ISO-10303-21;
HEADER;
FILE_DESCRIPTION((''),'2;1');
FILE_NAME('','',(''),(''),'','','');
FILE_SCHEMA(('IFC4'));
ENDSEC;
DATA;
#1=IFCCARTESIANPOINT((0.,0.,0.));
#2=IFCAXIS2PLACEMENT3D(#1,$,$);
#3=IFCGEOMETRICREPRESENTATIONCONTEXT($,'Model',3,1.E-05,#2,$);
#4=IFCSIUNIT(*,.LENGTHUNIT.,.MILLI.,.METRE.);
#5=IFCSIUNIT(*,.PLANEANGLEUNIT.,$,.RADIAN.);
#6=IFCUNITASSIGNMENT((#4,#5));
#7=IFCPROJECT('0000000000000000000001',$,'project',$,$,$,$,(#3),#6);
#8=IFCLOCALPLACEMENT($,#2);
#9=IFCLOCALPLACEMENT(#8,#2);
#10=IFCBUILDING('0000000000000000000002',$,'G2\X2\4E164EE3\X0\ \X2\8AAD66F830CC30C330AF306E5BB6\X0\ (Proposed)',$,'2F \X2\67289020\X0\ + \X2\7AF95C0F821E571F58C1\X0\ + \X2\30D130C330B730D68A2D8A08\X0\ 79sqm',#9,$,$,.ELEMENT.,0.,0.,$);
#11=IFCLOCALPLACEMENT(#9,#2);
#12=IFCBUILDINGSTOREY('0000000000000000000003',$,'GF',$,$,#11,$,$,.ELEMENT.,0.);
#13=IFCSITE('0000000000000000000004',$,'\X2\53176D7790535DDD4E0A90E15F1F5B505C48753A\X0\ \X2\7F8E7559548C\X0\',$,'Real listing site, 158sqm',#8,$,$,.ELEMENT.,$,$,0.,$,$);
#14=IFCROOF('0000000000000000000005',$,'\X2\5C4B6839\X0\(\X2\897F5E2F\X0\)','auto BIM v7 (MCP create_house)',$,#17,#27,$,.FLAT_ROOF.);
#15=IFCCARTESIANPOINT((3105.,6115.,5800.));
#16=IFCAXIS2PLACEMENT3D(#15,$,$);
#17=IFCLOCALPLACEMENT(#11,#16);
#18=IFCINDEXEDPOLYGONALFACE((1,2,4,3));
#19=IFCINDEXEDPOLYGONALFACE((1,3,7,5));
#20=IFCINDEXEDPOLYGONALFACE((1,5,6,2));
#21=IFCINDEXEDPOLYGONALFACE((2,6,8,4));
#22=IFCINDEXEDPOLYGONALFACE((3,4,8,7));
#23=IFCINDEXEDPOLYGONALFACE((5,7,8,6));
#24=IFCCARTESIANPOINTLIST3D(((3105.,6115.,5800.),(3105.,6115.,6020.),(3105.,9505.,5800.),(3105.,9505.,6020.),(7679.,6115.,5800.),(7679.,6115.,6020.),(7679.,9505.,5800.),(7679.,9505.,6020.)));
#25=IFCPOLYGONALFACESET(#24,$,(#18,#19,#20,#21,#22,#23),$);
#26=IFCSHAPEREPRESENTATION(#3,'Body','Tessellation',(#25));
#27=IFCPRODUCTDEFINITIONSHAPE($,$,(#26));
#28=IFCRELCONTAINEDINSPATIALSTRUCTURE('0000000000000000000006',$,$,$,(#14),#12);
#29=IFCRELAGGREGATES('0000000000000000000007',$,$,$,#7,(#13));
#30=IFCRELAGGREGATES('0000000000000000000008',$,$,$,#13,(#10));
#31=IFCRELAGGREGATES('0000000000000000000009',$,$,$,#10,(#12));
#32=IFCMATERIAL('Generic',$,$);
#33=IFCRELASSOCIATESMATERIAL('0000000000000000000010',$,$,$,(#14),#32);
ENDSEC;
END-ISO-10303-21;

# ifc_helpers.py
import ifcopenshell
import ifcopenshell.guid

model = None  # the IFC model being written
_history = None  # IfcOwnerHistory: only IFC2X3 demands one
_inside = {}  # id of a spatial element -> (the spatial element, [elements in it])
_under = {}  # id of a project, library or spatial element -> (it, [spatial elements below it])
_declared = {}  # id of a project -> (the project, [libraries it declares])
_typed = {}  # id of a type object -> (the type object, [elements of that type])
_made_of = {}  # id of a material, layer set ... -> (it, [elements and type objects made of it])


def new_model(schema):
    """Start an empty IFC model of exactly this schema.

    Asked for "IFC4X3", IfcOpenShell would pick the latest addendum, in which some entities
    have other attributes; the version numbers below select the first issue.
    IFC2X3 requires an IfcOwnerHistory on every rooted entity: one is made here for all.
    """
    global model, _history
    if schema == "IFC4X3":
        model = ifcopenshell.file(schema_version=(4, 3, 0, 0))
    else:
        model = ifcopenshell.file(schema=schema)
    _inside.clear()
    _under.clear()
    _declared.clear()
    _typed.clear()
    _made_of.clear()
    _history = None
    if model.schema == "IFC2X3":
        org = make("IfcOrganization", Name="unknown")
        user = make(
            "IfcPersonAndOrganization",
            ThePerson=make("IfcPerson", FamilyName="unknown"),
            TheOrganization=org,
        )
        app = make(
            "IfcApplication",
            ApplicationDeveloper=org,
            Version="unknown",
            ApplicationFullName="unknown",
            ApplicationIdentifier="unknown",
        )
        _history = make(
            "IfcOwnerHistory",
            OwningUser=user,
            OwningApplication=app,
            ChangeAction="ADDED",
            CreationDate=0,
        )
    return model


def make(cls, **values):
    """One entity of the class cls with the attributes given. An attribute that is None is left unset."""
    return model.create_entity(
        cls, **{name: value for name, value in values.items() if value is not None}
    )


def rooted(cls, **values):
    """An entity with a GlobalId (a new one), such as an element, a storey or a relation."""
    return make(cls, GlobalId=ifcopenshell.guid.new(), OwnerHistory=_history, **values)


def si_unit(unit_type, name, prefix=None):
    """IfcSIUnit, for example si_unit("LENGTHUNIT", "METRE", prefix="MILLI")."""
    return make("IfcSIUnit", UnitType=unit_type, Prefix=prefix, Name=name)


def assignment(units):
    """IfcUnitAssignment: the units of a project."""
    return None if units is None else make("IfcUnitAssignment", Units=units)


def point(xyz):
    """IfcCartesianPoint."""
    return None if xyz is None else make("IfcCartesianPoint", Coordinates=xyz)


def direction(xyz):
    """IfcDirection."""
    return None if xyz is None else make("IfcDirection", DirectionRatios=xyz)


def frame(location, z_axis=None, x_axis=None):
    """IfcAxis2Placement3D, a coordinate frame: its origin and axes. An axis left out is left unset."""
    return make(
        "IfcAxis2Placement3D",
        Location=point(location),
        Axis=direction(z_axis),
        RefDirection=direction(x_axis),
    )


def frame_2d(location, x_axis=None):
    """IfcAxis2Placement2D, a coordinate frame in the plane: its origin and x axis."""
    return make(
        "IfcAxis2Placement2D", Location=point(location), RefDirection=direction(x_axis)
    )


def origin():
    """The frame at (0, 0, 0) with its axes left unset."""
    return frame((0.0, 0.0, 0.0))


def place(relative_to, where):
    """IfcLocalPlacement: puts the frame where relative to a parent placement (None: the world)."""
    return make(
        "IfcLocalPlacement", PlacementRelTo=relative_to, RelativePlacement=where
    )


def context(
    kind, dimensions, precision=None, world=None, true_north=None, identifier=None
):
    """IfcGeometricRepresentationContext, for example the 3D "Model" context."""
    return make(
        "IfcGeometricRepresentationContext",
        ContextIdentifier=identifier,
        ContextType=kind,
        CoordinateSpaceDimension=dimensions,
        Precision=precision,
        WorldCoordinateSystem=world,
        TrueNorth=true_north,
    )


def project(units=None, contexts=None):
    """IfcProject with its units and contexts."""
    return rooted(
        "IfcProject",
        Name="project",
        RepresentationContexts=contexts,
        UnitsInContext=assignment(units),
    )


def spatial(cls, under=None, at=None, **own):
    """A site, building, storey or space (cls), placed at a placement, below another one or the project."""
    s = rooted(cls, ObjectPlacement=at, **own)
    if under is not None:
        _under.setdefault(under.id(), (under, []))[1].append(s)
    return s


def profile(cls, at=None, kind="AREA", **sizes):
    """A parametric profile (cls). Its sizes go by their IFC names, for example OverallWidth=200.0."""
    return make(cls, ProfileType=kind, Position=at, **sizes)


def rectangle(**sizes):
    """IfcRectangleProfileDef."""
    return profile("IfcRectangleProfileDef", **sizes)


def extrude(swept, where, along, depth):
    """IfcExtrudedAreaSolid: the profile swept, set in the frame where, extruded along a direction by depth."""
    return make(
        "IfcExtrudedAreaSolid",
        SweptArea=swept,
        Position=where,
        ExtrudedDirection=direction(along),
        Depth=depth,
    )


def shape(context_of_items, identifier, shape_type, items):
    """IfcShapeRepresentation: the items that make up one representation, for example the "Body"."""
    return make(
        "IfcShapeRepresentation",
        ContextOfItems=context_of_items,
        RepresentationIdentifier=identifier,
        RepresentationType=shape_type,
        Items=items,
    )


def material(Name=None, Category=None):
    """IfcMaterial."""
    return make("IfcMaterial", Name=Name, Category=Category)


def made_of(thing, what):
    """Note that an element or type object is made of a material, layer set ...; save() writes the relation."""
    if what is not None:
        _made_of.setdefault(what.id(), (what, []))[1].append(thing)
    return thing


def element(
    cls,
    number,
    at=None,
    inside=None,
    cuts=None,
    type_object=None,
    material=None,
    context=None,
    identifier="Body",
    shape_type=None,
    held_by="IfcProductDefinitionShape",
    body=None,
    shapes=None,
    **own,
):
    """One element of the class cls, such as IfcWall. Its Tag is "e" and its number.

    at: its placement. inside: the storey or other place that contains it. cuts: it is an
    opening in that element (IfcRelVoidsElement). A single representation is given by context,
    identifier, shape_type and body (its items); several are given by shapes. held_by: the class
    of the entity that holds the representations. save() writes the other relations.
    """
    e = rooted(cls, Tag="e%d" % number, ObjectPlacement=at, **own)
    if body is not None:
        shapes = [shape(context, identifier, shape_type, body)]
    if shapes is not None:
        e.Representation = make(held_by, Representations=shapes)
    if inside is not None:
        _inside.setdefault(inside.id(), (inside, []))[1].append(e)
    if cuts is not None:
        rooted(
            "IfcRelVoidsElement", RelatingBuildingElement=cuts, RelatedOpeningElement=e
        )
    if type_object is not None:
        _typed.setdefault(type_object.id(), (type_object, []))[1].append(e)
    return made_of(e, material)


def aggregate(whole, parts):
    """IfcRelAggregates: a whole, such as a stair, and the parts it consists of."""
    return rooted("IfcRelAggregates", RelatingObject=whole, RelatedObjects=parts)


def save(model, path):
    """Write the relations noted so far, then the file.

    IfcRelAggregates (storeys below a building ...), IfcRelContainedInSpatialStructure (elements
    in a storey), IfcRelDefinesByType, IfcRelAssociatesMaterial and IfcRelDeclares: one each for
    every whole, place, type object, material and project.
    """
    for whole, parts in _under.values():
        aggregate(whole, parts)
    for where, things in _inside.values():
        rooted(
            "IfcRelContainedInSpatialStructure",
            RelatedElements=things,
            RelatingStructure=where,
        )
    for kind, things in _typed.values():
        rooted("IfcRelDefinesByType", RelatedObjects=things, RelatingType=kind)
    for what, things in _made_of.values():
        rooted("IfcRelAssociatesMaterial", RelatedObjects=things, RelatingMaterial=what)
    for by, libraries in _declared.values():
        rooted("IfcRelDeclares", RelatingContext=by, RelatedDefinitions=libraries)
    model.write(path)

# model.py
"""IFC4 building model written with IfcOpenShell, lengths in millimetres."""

from ifc_helpers import new_model, si_unit, frame, frame_2d, origin, place, context, project, spatial, rectangle, extrude, material, element, save


model = new_model("IFC4")

# Units and contexts
model_context = context("Model", 3, precision=1e-05, world=origin())
ifc_project = project(units=[si_unit("LENGTHUNIT", "METRE", prefix="MILLI"), si_unit("PLANEANGLEUNIT", "RADIAN")], contexts=[model_context])

# Site, building, storey
site_placement = place(None, origin())
site = spatial("IfcSite", under=ifc_project, at=site_placement, Name="北海道川上郡弟子屈町 美留和", ObjectType="Real listing site, 158sqm", CompositionType="ELEMENT", RefElevation=0.0)
building_placement = place(site_placement, origin())
building = spatial("IfcBuilding", under=site, at=building_placement, Name="G2世代 読書ヌックの家 (Proposed)", ObjectType="2F 木造 + 竹小舞土壁 + パッシブ設計 79sqm", CompositionType="ELEMENT", ElevationOfRefHeight=0.0, ElevationOfTerrain=0.0)
storey_placement = place(building_placement, origin())
storey = spatial("IfcBuildingStorey", under=building, at=storey_placement, Name="GF", CompositionType="ELEMENT", Elevation=0.0)

# Shared definitions
ifc_material = material(Name="Generic")

# Roof
roof_1_placement = place(storey_placement, frame((3105.0, 6115.0, 5800.0)))
element("IfcRoof", 1, at=roof_1_placement, inside=storey, material=ifc_material, Name="屋根(西帯)", Description="auto BIM v7 (MCP create_house)", PredefinedType="FLAT_ROOF", context=model_context, shape_type="SweptSolid", body=[
    extrude(rectangle(XDim=4574.0, YDim=3390.0, at=frame_2d((2287.0, 1695.0))), frame((3105.0, 6115.0, 5800.0)), (0.0, 0.0, 1.0), 220.0),
])

save(model, "model.ifc")
